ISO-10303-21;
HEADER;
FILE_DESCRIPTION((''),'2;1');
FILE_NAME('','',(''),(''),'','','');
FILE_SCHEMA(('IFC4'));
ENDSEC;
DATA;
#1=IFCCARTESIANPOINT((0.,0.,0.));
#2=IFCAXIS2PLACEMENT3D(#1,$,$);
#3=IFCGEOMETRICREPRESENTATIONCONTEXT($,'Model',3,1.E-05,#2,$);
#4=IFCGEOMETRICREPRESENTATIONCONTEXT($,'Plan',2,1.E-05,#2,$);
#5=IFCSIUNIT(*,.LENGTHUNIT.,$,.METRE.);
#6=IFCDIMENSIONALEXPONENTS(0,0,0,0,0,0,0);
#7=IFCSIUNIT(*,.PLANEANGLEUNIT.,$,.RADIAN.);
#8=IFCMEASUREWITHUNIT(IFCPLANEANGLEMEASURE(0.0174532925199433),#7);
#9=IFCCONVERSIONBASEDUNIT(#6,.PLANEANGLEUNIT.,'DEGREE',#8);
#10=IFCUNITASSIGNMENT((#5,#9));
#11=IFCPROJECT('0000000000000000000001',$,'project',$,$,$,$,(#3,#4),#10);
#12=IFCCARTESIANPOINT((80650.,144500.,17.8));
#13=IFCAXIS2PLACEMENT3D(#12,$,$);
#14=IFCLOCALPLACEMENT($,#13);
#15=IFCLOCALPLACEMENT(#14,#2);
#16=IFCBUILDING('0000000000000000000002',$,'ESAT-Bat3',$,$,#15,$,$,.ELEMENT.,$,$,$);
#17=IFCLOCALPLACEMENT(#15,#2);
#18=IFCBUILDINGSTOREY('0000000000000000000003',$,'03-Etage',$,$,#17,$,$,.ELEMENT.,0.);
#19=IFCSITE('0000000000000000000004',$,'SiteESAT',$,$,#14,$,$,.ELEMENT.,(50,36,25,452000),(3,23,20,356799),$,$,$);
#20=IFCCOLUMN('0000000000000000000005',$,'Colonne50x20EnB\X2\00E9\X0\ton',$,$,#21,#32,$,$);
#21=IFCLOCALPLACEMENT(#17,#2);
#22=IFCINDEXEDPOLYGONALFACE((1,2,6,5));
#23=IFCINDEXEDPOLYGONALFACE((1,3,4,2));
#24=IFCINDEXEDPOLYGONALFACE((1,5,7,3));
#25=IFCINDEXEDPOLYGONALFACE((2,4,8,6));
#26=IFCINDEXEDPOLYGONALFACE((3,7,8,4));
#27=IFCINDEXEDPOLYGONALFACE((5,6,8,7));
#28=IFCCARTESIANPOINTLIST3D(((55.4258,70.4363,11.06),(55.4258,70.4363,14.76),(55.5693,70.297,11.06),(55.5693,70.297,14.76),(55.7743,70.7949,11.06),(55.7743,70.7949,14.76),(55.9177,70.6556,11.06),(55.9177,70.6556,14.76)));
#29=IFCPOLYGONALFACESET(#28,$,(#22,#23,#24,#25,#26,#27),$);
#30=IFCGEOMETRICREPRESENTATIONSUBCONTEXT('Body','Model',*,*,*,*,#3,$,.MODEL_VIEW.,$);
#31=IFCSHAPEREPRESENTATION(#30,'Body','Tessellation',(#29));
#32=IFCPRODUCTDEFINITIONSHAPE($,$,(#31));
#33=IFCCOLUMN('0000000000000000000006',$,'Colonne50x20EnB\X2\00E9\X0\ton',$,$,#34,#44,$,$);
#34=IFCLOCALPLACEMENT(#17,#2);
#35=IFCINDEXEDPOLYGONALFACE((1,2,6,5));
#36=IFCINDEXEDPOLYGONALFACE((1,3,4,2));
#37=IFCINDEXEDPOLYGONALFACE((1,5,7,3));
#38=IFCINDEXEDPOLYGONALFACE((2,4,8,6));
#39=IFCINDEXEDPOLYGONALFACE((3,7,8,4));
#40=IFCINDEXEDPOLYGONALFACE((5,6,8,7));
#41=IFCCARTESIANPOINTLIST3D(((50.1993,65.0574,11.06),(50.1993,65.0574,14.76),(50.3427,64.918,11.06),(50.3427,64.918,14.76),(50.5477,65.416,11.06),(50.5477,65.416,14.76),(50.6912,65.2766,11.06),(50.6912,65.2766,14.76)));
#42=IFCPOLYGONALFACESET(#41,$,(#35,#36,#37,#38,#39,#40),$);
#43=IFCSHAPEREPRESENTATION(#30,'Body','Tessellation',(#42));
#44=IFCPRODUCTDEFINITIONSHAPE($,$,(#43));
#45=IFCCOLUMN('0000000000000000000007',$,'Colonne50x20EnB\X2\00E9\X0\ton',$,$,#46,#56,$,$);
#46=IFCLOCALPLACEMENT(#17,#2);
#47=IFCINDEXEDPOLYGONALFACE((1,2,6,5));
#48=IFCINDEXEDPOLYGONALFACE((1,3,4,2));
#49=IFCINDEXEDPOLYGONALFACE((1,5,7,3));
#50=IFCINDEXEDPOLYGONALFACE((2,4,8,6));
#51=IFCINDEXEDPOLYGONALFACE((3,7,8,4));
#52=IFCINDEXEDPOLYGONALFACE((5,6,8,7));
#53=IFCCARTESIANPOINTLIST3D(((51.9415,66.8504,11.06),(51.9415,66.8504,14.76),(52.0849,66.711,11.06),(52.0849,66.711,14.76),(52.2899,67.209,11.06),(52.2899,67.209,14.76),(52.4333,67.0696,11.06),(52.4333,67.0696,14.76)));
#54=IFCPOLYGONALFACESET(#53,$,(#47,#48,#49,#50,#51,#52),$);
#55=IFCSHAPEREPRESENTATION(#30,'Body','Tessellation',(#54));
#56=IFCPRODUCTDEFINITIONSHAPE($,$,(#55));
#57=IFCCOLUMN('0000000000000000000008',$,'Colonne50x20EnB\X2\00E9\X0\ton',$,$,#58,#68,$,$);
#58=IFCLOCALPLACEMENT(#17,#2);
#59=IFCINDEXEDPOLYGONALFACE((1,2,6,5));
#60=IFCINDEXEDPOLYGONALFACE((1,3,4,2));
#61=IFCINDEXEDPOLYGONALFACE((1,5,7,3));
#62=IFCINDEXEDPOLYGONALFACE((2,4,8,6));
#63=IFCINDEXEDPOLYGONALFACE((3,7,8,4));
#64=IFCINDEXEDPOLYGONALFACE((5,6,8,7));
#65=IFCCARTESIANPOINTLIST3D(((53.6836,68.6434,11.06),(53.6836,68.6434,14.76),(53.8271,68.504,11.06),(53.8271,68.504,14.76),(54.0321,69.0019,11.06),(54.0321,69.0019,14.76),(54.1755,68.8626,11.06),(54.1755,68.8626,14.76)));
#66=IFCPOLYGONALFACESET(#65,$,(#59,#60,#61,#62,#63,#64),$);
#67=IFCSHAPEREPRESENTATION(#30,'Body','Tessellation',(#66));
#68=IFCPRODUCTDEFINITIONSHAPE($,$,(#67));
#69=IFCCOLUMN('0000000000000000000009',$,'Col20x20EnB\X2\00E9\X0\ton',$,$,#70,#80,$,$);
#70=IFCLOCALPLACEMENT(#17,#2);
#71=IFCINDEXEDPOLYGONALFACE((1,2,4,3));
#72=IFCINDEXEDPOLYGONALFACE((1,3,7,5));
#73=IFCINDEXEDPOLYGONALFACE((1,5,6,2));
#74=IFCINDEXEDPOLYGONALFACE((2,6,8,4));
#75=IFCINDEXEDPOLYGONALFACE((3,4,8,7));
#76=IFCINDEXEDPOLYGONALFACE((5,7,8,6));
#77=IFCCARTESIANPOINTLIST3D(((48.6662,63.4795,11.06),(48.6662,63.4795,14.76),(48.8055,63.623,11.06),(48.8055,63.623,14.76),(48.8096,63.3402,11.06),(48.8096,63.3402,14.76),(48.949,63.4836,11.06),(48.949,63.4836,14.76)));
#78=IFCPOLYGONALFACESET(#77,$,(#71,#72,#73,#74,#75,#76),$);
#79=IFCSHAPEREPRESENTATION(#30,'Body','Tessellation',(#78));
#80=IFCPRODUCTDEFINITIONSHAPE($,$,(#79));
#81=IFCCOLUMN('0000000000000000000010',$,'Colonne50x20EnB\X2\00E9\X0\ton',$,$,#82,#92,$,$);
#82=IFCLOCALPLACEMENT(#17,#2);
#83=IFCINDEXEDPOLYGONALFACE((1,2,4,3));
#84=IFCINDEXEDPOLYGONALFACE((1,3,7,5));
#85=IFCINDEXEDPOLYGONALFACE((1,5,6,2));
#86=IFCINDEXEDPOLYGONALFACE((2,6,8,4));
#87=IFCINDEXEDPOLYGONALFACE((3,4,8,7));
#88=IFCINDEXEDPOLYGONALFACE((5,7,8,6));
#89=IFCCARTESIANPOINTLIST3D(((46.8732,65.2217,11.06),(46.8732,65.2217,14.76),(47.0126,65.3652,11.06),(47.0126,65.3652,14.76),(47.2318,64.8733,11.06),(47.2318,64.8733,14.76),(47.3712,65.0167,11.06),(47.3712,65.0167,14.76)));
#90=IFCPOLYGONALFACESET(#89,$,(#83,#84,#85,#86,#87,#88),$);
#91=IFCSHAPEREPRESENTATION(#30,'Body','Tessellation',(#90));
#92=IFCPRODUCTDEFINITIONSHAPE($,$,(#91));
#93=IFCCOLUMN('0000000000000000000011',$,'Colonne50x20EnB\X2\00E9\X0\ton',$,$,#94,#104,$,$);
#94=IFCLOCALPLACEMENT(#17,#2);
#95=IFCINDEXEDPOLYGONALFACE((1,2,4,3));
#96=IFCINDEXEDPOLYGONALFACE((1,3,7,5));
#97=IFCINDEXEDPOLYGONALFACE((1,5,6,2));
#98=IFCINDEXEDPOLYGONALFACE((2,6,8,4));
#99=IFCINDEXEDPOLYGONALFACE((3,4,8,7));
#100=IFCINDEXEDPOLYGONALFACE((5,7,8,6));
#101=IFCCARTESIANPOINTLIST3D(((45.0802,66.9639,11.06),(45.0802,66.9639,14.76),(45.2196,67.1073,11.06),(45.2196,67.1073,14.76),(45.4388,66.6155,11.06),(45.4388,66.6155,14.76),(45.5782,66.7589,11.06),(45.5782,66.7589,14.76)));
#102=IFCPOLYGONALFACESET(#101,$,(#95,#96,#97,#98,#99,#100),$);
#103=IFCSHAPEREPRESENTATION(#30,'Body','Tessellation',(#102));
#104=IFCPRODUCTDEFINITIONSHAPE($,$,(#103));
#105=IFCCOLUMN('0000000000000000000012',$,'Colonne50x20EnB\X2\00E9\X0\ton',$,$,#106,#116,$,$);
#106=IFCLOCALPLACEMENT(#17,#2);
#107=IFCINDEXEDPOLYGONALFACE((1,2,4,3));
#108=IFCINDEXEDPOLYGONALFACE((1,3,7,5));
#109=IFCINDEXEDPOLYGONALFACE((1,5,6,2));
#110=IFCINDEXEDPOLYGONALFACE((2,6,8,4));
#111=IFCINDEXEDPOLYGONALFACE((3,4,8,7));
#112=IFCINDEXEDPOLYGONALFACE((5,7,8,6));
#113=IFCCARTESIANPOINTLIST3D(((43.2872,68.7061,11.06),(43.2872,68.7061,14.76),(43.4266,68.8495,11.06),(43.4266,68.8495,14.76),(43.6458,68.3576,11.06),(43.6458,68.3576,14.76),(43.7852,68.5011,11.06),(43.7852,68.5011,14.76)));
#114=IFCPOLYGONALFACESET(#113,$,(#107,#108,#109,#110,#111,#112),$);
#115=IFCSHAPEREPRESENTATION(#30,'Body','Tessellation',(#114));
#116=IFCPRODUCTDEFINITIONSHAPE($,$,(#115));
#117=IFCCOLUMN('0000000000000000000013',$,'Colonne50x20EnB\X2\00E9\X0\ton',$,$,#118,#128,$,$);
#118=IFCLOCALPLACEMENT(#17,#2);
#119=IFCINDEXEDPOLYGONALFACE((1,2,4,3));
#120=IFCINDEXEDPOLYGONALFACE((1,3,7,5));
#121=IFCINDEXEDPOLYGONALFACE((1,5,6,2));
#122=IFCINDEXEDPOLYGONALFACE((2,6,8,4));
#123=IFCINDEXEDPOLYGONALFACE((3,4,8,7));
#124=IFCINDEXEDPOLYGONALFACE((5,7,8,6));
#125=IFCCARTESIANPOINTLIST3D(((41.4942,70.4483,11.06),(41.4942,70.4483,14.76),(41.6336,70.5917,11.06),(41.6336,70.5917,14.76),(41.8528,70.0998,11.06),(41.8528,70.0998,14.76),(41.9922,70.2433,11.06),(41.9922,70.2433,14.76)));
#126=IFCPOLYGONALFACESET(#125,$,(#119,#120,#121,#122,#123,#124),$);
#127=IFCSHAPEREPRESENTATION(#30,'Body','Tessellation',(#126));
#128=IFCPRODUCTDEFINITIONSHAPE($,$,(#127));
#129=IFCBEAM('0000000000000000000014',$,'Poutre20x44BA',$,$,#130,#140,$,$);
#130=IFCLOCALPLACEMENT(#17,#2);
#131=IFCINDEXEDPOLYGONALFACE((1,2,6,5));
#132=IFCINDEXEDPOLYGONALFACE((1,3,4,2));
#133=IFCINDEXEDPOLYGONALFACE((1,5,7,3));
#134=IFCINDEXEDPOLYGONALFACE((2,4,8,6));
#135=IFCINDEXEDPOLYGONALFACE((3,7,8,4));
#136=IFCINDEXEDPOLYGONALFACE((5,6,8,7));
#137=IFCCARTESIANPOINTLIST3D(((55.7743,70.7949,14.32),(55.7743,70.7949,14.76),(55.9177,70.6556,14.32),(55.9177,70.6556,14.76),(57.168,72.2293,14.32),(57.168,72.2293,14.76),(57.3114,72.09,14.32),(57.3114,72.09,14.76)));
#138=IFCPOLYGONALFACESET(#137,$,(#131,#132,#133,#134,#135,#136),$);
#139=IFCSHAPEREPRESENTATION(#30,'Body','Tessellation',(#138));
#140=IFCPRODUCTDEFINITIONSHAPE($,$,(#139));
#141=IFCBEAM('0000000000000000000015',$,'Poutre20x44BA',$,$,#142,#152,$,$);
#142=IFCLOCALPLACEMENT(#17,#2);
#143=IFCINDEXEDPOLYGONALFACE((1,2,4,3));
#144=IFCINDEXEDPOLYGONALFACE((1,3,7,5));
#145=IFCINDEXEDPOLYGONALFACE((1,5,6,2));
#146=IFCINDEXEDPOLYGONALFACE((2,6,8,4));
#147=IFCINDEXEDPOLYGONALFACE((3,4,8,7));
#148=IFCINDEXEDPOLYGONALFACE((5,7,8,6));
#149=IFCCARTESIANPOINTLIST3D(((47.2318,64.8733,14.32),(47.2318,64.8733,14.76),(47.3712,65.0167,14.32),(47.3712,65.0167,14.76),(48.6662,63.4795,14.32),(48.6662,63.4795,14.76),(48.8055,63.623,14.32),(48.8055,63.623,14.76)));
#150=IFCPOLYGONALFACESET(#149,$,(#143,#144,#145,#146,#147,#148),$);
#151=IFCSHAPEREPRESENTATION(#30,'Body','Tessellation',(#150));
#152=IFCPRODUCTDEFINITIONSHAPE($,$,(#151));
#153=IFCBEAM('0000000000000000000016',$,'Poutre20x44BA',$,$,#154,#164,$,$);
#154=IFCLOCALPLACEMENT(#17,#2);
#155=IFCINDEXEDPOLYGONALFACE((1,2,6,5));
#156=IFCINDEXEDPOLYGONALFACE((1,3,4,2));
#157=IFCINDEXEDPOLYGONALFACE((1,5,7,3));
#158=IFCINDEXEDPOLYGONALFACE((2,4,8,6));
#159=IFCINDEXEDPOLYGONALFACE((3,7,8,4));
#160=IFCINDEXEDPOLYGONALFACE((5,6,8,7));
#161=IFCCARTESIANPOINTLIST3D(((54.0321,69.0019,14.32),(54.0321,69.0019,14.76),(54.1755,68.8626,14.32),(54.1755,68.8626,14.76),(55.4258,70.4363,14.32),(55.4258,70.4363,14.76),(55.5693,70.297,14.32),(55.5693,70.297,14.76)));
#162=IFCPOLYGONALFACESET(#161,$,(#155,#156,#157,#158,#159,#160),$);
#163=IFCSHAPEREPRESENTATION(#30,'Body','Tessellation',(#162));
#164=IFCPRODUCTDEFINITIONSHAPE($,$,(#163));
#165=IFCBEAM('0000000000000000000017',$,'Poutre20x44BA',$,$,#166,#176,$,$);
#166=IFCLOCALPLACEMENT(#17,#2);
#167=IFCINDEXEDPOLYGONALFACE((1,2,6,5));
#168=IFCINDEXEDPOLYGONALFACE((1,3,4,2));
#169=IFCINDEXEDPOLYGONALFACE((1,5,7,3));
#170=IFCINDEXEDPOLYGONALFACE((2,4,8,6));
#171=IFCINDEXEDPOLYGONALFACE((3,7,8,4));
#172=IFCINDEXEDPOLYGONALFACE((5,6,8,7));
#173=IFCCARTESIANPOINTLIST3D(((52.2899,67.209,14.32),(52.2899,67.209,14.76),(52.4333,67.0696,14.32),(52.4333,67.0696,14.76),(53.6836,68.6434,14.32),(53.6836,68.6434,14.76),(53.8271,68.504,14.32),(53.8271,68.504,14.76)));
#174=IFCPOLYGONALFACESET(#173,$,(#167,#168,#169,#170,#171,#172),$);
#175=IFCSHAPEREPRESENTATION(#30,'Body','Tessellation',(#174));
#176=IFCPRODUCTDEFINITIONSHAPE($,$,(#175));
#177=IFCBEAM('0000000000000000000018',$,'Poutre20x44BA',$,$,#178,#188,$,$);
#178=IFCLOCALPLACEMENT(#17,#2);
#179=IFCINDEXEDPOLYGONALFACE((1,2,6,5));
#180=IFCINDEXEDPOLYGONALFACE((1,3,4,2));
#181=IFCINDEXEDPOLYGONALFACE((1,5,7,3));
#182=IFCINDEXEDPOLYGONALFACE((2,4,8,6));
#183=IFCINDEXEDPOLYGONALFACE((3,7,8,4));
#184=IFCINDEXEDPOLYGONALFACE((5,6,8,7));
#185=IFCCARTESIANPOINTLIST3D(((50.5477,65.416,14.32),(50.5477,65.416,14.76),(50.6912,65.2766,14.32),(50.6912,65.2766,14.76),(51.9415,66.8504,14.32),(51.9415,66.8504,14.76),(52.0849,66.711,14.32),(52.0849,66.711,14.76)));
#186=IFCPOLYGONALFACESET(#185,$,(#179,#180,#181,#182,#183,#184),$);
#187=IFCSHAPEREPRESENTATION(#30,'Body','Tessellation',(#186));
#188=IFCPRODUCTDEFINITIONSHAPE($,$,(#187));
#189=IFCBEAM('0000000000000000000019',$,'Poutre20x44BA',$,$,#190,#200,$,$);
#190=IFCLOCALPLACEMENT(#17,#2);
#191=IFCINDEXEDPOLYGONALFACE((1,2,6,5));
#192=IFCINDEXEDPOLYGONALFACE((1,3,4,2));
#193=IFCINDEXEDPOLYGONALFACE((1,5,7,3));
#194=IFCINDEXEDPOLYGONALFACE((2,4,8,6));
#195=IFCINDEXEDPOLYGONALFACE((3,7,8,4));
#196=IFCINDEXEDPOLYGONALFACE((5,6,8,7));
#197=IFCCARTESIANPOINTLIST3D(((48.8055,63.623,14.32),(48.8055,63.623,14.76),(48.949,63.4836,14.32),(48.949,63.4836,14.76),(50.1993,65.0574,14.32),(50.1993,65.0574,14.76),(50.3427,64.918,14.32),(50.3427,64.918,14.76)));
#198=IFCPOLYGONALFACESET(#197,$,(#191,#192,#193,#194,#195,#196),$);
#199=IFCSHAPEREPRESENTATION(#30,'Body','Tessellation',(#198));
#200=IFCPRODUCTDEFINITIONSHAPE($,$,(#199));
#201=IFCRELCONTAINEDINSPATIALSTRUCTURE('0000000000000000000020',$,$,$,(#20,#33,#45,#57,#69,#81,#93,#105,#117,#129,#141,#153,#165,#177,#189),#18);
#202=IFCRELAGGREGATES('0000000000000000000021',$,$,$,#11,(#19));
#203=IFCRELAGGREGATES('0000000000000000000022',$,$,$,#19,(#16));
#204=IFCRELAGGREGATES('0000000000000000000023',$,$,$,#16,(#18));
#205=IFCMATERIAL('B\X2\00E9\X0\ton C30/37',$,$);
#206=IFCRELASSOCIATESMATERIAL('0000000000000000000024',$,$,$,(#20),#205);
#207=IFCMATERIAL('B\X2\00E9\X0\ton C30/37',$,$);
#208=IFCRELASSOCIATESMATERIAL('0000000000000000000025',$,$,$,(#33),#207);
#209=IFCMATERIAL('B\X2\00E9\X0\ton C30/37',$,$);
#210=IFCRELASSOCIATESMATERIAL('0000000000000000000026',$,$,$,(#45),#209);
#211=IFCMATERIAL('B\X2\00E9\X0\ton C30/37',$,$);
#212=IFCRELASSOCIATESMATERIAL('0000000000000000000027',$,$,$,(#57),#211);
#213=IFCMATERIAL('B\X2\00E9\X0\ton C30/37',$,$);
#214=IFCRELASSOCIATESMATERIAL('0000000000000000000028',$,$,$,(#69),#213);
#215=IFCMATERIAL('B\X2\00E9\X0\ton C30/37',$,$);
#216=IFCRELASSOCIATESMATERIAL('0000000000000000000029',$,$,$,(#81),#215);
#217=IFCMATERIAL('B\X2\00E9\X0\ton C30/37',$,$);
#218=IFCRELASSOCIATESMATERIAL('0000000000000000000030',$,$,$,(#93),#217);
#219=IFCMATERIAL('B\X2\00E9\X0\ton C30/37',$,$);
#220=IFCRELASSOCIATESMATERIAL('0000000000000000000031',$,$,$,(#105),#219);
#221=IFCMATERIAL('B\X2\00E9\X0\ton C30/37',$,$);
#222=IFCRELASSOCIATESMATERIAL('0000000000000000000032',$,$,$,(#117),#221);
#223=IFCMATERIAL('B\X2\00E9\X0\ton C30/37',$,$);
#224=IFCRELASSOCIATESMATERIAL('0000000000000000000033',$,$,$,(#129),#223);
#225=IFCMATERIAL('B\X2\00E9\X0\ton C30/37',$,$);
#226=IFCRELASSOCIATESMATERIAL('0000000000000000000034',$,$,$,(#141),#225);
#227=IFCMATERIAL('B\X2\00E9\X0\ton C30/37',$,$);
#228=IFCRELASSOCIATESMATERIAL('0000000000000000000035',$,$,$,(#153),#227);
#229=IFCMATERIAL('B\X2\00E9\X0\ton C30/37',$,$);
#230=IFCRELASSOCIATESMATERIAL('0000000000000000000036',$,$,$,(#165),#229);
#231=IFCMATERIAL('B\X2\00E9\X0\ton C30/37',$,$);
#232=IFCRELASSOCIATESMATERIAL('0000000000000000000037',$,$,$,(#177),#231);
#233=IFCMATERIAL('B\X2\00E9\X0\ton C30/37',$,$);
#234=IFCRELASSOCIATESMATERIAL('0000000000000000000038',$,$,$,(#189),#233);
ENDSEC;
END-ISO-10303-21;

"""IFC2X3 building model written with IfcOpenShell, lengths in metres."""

from ifc_helpers import new_model, entity, si_unit, converted_unit, frame, frame_2d, origin, origin_with_axes, place, context, subcontext, project, spatial, rectangle, extrude, material, element, save


model = new_model("IFC2X3")

# Units and contexts
model_context = context("Model", 3, precision=1e-05, world=origin())
plan_context = context("Plan", 2, precision=1e-05, world=origin())
body_context = subcontext(model_context, "Body", "Model", "MODEL_VIEW")
ifc_project = project(units=[si_unit("LENGTHUNIT", "METRE"), converted_unit("PLANEANGLEUNIT", "DEGREE", entity("IfcPlaneAngleMeasure", 0.0174532925199433), si_unit("PLANEANGLEUNIT", "RADIAN"), dimensions=[0, 0, 0, 0, 0, 0, 0])], contexts=[model_context, plan_context])

# Site, building, storey
site_placement = place(None, frame((80650.0, 144500.0, 17.8)))
site = spatial("IfcSite", under=ifc_project, at=site_placement, Name="SiteESAT", CompositionType="ELEMENT", RefLatitude=(50, 36, 25, 452000), RefLongitude=(3, 23, 20, 356799))
building_placement = place(site_placement, origin())
building = spatial("IfcBuilding", under=site, at=building_placement, Name="ESAT-Bat3", CompositionType="ELEMENT")
storey_placement = place(building_placement, origin())
storey = spatial("IfcBuildingStorey", under=building, at=storey_placement, Name="03-Etage", CompositionType="ELEMENT", Elevation=0.0)

# Columns
ifc_material_1 = material(Name="Béton C30/37")
column_1_placement = place(storey_placement, frame((55.5693, 70.297, 11.06)))
element("IfcColumn", 1, at=column_1_placement, inside=storey, material=ifc_material_1, Name="Colonne50x20EnBéton", context=body_context, shape_type="SweptSolid", body=[
    extrude(rectangle(XDim=0.5, YDim=0.2, at=frame_2d((0.1025, 0.249), x_axis=(0.696872, 0.717196))), origin_with_axes(), (0.0, 0.0, 1.0), 3.7),
])
ifc_material_2 = material(Name="Béton C30/37")
column_2_placement = place(storey_placement, frame((50.3427, 64.918, 11.06)))
element("IfcColumn", 2, at=column_2_placement, inside=storey, material=ifc_material_2, Name="Colonne50x20EnBéton", context=body_context, shape_type="SweptSolid", body=[
    extrude(rectangle(XDim=0.5, YDim=0.2, at=frame_2d((0.1025, 0.249), x_axis=(0.696872, 0.717196))), origin_with_axes(), (0.0, 0.0, 1.0), 3.7),
])
ifc_material_3 = material(Name="Béton C30/37")
column_3_placement = place(storey_placement, frame((52.0849, 66.711, 11.06)))
element("IfcColumn", 3, at=column_3_placement, inside=storey, material=ifc_material_3, Name="Colonne50x20EnBéton", context=body_context, shape_type="SweptSolid", body=[
    extrude(rectangle(XDim=0.5, YDim=0.2, at=frame_2d((0.1025, 0.249), x_axis=(0.696872, 0.717196))), origin_with_axes(), (0.0, 0.0, 1.0), 3.7),
])
ifc_material_4 = material(Name="Béton C30/37")
column_4_placement = place(storey_placement, frame((53.8271, 68.504, 11.06)))
element("IfcColumn", 4, at=column_4_placement, inside=storey, material=ifc_material_4, Name="Colonne50x20EnBéton", context=body_context, shape_type="SweptSolid", body=[
    extrude(rectangle(XDim=0.5, YDim=0.2, at=frame_2d((0.1025, 0.249), x_axis=(0.696872, 0.717196))), origin_with_axes(), (0.0, 0.0, 1.0), 3.7),
])
ifc_material_5 = material(Name="Béton C30/37")
column_5_placement = place(storey_placement, frame((48.8096, 63.3402, 11.06)))
element("IfcColumn", 5, at=column_5_placement, inside=storey, material=ifc_material_5, Name="Col20x20EnBéton", context=body_context, shape_type="SweptSolid", body=[
    extrude(rectangle(XDim=0.2, YDim=0.2, at=frame_2d((-0.002, 0.1414), x_axis=(0.696872, 0.717196))), origin_with_axes(), (0.0, 0.0, 1.0), 3.7),
])
ifc_material_6 = material(Name="Béton C30/37")
column_6_placement = place(storey_placement, frame((47.3712, 65.0167, 11.06)))
element("IfcColumn", 6, at=column_6_placement, inside=storey, material=ifc_material_6, Name="Colonne50x20EnBéton", context=body_context, shape_type="SweptSolid", body=[
    extrude(rectangle(XDim=0.5, YDim=0.2, at=frame_2d((-0.249, 0.1025), x_axis=(-0.717196, 0.696872))), origin_with_axes(), (0.0, 0.0, 1.0), 3.7),
])
ifc_material_7 = material(Name="Béton C30/37")
column_7_placement = place(storey_placement, frame((45.5782, 66.7589, 11.06)))
element("IfcColumn", 7, at=column_7_placement, inside=storey, material=ifc_material_7, Name="Colonne50x20EnBéton", context=body_context, shape_type="SweptSolid", body=[
    extrude(rectangle(XDim=0.5, YDim=0.2, at=frame_2d((-0.249, 0.1025), x_axis=(-0.717196, 0.696872))), origin_with_axes(), (0.0, 0.0, 1.0), 3.7),
])
ifc_material_8 = material(Name="Béton C30/37")
column_8_placement = place(storey_placement, frame((43.7852, 68.5011, 11.06)))
element("IfcColumn", 8, at=column_8_placement, inside=storey, material=ifc_material_8, Name="Colonne50x20EnBéton", context=body_context, shape_type="SweptSolid", body=[
    extrude(rectangle(XDim=0.5, YDim=0.2, at=frame_2d((-0.249, 0.1025), x_axis=(-0.717196, 0.696872))), origin_with_axes(), (0.0, 0.0, 1.0), 3.7),
])
ifc_material_9 = material(Name="Béton C30/37")
column_9_placement = place(storey_placement, frame((41.9922, 70.2433, 11.06)))
element("IfcColumn", 9, at=column_9_placement, inside=storey, material=ifc_material_9, Name="Colonne50x20EnBéton", context=body_context, shape_type="SweptSolid", body=[
    extrude(rectangle(XDim=0.5, YDim=0.2, at=frame_2d((-0.249, 0.1025), x_axis=(-0.717196, 0.696872))), origin_with_axes(), (0.0, 0.0, 1.0), 3.7),
])

# Beams
ifc_material_10 = material(Name="Béton C30/37")
beam_1_placement = place(storey_placement, frame((55.9177, 70.6556, 14.32), z_axis=(0.0, 0.0, 1.0), x_axis=(0.696872, 0.717196, 0.0)))
element("IfcBeam", 10, at=beam_1_placement, inside=storey, material=ifc_material_10, Name="Poutre20x44BA", context=body_context, shape_type="SweptSolid", body=[
    extrude(rectangle(XDim=0.2, YDim=0.44, at=frame_2d((0.1, 0.22), x_axis=(1.0, 0.0))), frame((0.0, 0.0, 0.0), z_axis=(1.0, 0.0, 0.0), x_axis=(0.0, 1.0, 0.0)), (0.0, 0.0, 1.0), 2.0),
])
ifc_material_11 = material(Name="Béton C30/37")
beam_2_placement = place(storey_placement, frame((48.8055, 63.623, 14.32), z_axis=(0.0, 0.0, 1.0), x_axis=(-0.717196, 0.696872, 0.0)))
element("IfcBeam", 11, at=beam_2_placement, inside=storey, material=ifc_material_11, Name="Poutre20x44BA", context=body_context, shape_type="SweptSolid", body=[
    extrude(rectangle(XDim=0.2, YDim=0.44, at=frame_2d((0.1, 0.22), x_axis=(1.0, 0.0))), frame((0.0, 0.0, 0.0), z_axis=(1.0, 0.0, 0.0), x_axis=(0.0, 1.0, 0.0)), (0.0, 0.0, 1.0), 2.0),
])
ifc_material_12 = material(Name="Béton C30/37")
beam_3_placement = place(storey_placement, frame((54.1755, 68.8626, 14.32), z_axis=(0.0, 0.0, 1.0), x_axis=(0.696872, 0.717196, 0.0)))
element("IfcBeam", 12, at=beam_3_placement, inside=storey, material=ifc_material_12, Name="Poutre20x44BA", context=body_context, shape_type="SweptSolid", body=[
    extrude(rectangle(XDim=0.2, YDim=0.44, at=frame_2d((0.1, 0.22), x_axis=(1.0, 0.0))), frame((0.0, 0.0, 0.0), z_axis=(1.0, 0.0, 0.0), x_axis=(0.0, 1.0, 0.0)), (0.0, 0.0, 1.0), 2.0),
])
ifc_material_13 = material(Name="Béton C30/37")
beam_4_placement = place(storey_placement, frame((52.4333, 67.0696, 14.32), z_axis=(0.0, 0.0, 1.0), x_axis=(0.696872, 0.717196, 0.0)))
element("IfcBeam", 13, at=beam_4_placement, inside=storey, material=ifc_material_13, Name="Poutre20x44BA", context=body_context, shape_type="SweptSolid", body=[
    extrude(rectangle(XDim=0.2, YDim=0.44, at=frame_2d((0.1, 0.22), x_axis=(1.0, 0.0))), frame((0.0, 0.0, 0.0), z_axis=(1.0, 0.0, 0.0), x_axis=(0.0, 1.0, 0.0)), (0.0, 0.0, 1.0), 2.0),
])
ifc_material_14 = material(Name="Béton C30/37")
beam_5_placement = place(storey_placement, frame((50.6912, 65.2766, 14.32), z_axis=(0.0, 0.0, 1.0), x_axis=(0.696872, 0.717196, 0.0)))
element("IfcBeam", 14, at=beam_5_placement, inside=storey, material=ifc_material_14, Name="Poutre20x44BA", context=body_context, shape_type="SweptSolid", body=[
    extrude(rectangle(XDim=0.2, YDim=0.44, at=frame_2d((0.1, 0.22), x_axis=(1.0, 0.0))), frame((0.0, 0.0, 0.0), z_axis=(1.0, 0.0, 0.0), x_axis=(0.0, 1.0, 0.0)), (0.0, 0.0, 1.0), 2.0),
])
ifc_material_15 = material(Name="Béton C30/37")
beam_6_placement = place(storey_placement, frame((48.949, 63.4836, 14.32), z_axis=(0.0, 0.0, 1.0), x_axis=(0.696872, 0.717196, 0.0)))
element("IfcBeam", 15, at=beam_6_placement, inside=storey, material=ifc_material_15, Name="Poutre20x44BA", context=body_context, shape_type="SweptSolid", body=[
    extrude(rectangle(XDim=0.2, YDim=0.44, at=frame_2d((0.1, 0.22), x_axis=(1.0, 0.0))), frame((0.0, 0.0, 0.0), z_axis=(1.0, 0.0, 0.0), x_axis=(0.0, 1.0, 0.0)), (0.0, 0.0, 1.0), 2.0),
])

save(model, "model.ifc")
